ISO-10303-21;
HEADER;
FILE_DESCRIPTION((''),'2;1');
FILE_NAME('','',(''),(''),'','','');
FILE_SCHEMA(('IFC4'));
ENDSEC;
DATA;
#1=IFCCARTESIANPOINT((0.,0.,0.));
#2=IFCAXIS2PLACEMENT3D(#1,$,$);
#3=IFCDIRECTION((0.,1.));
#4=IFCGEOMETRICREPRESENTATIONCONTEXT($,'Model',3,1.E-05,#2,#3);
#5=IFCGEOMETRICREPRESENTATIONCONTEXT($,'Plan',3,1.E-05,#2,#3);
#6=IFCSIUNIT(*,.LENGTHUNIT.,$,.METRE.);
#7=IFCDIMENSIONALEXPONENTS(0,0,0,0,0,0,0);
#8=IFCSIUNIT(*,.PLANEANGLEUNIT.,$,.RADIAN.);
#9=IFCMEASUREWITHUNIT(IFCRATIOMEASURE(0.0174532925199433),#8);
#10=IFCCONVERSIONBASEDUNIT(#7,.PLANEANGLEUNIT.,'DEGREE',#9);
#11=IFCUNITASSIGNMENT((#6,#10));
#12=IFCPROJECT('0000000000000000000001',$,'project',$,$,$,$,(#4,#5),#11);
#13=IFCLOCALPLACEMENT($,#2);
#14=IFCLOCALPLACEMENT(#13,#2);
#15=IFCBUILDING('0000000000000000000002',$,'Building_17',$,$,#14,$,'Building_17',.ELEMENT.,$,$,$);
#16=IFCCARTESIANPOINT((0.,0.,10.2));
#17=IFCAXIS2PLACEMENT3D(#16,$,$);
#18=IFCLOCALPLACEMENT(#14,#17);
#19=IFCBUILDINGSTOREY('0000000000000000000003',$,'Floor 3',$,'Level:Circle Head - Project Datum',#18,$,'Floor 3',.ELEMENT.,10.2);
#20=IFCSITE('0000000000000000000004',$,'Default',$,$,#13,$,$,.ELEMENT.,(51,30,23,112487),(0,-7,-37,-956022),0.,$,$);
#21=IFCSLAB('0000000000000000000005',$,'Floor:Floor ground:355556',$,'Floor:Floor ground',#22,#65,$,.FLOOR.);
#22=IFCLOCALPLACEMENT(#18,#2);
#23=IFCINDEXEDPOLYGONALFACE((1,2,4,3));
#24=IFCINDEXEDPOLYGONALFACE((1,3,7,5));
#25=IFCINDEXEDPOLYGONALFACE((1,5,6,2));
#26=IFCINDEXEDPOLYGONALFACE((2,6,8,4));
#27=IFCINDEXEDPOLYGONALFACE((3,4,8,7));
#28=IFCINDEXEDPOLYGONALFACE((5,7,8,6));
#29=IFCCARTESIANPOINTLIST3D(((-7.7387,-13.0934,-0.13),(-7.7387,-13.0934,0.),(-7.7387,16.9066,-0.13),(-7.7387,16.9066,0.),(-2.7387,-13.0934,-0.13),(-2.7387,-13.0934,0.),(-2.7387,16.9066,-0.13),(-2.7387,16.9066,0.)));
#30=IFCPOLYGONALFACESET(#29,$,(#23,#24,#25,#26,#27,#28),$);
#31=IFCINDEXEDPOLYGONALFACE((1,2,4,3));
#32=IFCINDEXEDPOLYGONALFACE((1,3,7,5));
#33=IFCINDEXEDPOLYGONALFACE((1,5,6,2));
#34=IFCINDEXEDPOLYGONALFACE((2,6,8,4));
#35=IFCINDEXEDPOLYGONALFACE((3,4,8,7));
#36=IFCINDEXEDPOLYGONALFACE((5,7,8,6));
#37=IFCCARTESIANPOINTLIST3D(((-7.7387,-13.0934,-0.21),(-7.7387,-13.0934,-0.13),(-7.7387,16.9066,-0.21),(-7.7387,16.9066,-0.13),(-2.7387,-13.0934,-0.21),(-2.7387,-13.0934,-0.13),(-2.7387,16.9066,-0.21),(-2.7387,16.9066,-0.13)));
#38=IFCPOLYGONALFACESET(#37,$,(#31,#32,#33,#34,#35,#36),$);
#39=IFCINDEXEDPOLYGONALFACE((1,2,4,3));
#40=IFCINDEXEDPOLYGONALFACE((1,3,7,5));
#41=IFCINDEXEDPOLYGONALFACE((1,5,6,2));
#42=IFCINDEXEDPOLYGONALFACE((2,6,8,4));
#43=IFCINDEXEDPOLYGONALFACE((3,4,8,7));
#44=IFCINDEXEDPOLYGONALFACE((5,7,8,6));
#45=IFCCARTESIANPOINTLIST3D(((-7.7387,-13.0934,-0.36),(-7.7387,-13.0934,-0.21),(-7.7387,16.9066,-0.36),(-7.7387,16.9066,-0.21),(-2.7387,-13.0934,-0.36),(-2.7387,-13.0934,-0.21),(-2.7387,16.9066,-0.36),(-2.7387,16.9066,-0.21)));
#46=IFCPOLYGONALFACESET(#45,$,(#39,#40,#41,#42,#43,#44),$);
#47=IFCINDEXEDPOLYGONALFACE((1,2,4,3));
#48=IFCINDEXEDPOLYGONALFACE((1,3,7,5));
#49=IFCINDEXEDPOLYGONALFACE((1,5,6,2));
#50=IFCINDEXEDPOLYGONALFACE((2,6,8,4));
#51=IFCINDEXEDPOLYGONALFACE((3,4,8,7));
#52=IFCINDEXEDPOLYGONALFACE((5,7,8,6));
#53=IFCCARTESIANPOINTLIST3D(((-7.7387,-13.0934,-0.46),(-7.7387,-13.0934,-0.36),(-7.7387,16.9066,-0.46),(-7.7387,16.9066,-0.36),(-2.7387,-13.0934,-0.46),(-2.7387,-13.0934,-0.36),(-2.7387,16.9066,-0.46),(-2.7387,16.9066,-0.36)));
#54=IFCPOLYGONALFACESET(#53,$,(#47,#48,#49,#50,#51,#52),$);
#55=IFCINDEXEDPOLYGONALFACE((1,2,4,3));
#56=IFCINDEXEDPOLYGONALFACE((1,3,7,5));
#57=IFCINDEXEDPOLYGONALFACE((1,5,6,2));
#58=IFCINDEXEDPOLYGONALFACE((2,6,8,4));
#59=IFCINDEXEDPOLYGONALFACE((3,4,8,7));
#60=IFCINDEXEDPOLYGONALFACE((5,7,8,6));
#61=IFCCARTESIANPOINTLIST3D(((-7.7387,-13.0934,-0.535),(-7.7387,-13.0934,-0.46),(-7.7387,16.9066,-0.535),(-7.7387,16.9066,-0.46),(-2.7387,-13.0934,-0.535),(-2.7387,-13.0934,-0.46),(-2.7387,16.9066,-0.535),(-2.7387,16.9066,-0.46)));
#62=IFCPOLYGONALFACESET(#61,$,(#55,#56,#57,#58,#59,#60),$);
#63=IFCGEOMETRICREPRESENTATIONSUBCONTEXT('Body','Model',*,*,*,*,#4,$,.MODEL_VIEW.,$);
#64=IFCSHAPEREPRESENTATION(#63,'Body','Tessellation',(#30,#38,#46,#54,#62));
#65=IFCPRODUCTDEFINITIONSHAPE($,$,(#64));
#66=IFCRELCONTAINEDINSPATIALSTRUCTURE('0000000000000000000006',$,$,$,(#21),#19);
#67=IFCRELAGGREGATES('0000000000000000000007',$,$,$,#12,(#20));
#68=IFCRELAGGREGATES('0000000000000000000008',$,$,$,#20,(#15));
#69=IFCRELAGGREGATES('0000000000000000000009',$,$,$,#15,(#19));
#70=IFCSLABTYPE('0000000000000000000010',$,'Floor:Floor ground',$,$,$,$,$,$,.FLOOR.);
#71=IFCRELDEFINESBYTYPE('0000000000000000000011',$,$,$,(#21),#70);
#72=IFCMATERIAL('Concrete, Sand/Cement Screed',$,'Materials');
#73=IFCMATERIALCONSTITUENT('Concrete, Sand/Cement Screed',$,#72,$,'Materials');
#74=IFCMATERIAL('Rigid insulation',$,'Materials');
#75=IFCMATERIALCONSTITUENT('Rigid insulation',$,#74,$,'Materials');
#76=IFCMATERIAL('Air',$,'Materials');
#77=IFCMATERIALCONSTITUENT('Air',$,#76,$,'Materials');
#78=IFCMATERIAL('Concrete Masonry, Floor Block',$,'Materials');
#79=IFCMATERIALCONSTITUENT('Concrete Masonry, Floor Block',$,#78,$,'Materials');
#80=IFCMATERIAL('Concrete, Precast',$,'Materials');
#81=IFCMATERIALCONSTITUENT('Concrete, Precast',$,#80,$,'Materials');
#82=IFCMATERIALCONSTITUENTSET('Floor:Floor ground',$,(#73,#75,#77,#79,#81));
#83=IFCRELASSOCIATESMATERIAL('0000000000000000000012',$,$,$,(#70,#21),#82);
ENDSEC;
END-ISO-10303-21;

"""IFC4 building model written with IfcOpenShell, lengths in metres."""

from ifc_helpers import new_model, entity, si_unit, converted_unit, direction, frame, origin, place, context, subcontext, project, spatial, indexed_curve, outline, extrude, material, constituent, constituent_set, type_object, element, save


model = new_model("IFC4")

# Units and contexts
model_context = context("Model", 3, precision=1e-05, world=origin(), true_north=direction((0.0, 1.0)))
plan_context = context("Plan", 3, precision=1e-05, world=origin(), true_north=direction((0.0, 1.0)))
body_context = subcontext(model_context, "Body", "Model", "MODEL_VIEW")
ifc_project = project(units=[si_unit("LENGTHUNIT", "METRE"), converted_unit("PLANEANGLEUNIT", "DEGREE", entity("IfcRatioMeasure", 0.0174532925199433), si_unit("PLANEANGLEUNIT", "RADIAN"), dimensions=[0, 0, 0, 0, 0, 0, 0])], contexts=[model_context, plan_context])

# Site, building, storey
site_placement = place(None, origin())
site = spatial("IfcSite", under=ifc_project, at=site_placement, Name="Default", CompositionType="ELEMENT", RefLatitude=(51, 30, 23, 112487), RefLongitude=(0, -7, -37, -956022), RefElevation=0.0)
building_placement = place(site_placement, origin())
building = spatial("IfcBuilding", under=site, at=building_placement, Name="Building_17", LongName="Building_17", CompositionType="ELEMENT")
storey_placement = place(building_placement, frame((0.0, 0.0, 10.2)))
storey = spatial("IfcBuildingStorey", under=building, at=storey_placement, Name="Floor 3", ObjectType="Level:Circle Head - Project Datum", LongName="Floor 3", CompositionType="ELEMENT", Elevation=10.2)

# Slab
ifc_material_1 = material(Name="Concrete, Sand/Cement Screed", Category="Materials")
ifc_constituent_1 = constituent(ifc_material_1, Name="Concrete, Sand/Cement Screed", Category="Materials")
ifc_material_2 = material(Name="Rigid insulation", Category="Materials")
ifc_constituent_2 = constituent(ifc_material_2, Name="Rigid insulation", Category="Materials")
ifc_material_3 = material(Name="Air", Category="Materials")
ifc_constituent_3 = constituent(ifc_material_3, Name="Air", Category="Materials")
ifc_material_4 = material(Name="Concrete Masonry, Floor Block", Category="Materials")
ifc_constituent_4 = constituent(ifc_material_4, Name="Concrete Masonry, Floor Block", Category="Materials")
ifc_material_5 = material(Name="Concrete, Precast", Category="Materials")
ifc_constituent_5 = constituent(ifc_material_5, Name="Concrete, Precast", Category="Materials")
ifc_constituent_set_1 = constituent_set(constituents=[ifc_constituent_1, ifc_constituent_2, ifc_constituent_3, ifc_constituent_4, ifc_constituent_5], Name="Floor:Floor ground")
slab_type_1 = type_object("IfcSlabType", Name="Floor:Floor ground", PredefinedType="FLOOR", material=ifc_constituent_set_1)
slab_1_placement = place(storey_placement, origin())
element("IfcSlab", 1, at=slab_1_placement, inside=storey, type_object=slab_type_1, material=ifc_constituent_set_1, Name="Floor:Floor ground:355556", ObjectType="Floor:Floor ground", PredefinedType="FLOOR", context=body_context, shape_type="SweptSolid", body=[
    extrude(outline(indexed_curve([(-2.5, -15.0), (2.5, -15.0), (2.5, 15.0), (-2.5, 15.0), (-2.5, -15.0)], self_intersect=False)), frame((-5.2387, 1.9066, -0.13), z_axis=(0.0, 0.0, 1.0), x_axis=(-1.0, 0.0, 0.0)), (0.0, 0.0, 1.0), 0.13),
    extrude(outline(indexed_curve([(-2.5, -15.0), (2.5, -15.0), (2.5, 15.0), (-2.5, 15.0), (-2.5, -15.0)], self_intersect=False)), frame((-5.2387, 1.9066, -0.21), z_axis=(0.0, 0.0, 1.0), x_axis=(-1.0, 0.0, 0.0)), (0.0, 0.0, 1.0), 0.08),
    extrude(outline(indexed_curve([(-2.5, -15.0), (2.5, -15.0), (2.5, 15.0), (-2.5, 15.0), (-2.5, -15.0)], self_intersect=False)), frame((-5.2387, 1.9066, -0.36), z_axis=(0.0, 0.0, 1.0), x_axis=(-1.0, 0.0, 0.0)), (0.0, 0.0, 1.0), 0.15),
    extrude(outline(indexed_curve([(-2.5, -15.0), (2.5, -15.0), (2.5, 15.0), (-2.5, 15.0), (-2.5, -15.0)], self_intersect=False)), frame((-5.2387, 1.9066, -0.46), z_axis=(0.0, 0.0, 1.0), x_axis=(-1.0, 0.0, 0.0)), (0.0, 0.0, 1.0), 0.1),
    extrude(outline(indexed_curve([(-2.5, -15.0), (2.5, -15.0), (2.5, 15.0), (-2.5, 15.0), (-2.5, -15.0)], self_intersect=False)), frame((-5.2387, 1.9066, -0.535), z_axis=(0.0, 0.0, 1.0), x_axis=(-1.0, 0.0, 0.0)), (0.0, 0.0, 1.0), 0.075),
])

save(model, "model.ifc")
